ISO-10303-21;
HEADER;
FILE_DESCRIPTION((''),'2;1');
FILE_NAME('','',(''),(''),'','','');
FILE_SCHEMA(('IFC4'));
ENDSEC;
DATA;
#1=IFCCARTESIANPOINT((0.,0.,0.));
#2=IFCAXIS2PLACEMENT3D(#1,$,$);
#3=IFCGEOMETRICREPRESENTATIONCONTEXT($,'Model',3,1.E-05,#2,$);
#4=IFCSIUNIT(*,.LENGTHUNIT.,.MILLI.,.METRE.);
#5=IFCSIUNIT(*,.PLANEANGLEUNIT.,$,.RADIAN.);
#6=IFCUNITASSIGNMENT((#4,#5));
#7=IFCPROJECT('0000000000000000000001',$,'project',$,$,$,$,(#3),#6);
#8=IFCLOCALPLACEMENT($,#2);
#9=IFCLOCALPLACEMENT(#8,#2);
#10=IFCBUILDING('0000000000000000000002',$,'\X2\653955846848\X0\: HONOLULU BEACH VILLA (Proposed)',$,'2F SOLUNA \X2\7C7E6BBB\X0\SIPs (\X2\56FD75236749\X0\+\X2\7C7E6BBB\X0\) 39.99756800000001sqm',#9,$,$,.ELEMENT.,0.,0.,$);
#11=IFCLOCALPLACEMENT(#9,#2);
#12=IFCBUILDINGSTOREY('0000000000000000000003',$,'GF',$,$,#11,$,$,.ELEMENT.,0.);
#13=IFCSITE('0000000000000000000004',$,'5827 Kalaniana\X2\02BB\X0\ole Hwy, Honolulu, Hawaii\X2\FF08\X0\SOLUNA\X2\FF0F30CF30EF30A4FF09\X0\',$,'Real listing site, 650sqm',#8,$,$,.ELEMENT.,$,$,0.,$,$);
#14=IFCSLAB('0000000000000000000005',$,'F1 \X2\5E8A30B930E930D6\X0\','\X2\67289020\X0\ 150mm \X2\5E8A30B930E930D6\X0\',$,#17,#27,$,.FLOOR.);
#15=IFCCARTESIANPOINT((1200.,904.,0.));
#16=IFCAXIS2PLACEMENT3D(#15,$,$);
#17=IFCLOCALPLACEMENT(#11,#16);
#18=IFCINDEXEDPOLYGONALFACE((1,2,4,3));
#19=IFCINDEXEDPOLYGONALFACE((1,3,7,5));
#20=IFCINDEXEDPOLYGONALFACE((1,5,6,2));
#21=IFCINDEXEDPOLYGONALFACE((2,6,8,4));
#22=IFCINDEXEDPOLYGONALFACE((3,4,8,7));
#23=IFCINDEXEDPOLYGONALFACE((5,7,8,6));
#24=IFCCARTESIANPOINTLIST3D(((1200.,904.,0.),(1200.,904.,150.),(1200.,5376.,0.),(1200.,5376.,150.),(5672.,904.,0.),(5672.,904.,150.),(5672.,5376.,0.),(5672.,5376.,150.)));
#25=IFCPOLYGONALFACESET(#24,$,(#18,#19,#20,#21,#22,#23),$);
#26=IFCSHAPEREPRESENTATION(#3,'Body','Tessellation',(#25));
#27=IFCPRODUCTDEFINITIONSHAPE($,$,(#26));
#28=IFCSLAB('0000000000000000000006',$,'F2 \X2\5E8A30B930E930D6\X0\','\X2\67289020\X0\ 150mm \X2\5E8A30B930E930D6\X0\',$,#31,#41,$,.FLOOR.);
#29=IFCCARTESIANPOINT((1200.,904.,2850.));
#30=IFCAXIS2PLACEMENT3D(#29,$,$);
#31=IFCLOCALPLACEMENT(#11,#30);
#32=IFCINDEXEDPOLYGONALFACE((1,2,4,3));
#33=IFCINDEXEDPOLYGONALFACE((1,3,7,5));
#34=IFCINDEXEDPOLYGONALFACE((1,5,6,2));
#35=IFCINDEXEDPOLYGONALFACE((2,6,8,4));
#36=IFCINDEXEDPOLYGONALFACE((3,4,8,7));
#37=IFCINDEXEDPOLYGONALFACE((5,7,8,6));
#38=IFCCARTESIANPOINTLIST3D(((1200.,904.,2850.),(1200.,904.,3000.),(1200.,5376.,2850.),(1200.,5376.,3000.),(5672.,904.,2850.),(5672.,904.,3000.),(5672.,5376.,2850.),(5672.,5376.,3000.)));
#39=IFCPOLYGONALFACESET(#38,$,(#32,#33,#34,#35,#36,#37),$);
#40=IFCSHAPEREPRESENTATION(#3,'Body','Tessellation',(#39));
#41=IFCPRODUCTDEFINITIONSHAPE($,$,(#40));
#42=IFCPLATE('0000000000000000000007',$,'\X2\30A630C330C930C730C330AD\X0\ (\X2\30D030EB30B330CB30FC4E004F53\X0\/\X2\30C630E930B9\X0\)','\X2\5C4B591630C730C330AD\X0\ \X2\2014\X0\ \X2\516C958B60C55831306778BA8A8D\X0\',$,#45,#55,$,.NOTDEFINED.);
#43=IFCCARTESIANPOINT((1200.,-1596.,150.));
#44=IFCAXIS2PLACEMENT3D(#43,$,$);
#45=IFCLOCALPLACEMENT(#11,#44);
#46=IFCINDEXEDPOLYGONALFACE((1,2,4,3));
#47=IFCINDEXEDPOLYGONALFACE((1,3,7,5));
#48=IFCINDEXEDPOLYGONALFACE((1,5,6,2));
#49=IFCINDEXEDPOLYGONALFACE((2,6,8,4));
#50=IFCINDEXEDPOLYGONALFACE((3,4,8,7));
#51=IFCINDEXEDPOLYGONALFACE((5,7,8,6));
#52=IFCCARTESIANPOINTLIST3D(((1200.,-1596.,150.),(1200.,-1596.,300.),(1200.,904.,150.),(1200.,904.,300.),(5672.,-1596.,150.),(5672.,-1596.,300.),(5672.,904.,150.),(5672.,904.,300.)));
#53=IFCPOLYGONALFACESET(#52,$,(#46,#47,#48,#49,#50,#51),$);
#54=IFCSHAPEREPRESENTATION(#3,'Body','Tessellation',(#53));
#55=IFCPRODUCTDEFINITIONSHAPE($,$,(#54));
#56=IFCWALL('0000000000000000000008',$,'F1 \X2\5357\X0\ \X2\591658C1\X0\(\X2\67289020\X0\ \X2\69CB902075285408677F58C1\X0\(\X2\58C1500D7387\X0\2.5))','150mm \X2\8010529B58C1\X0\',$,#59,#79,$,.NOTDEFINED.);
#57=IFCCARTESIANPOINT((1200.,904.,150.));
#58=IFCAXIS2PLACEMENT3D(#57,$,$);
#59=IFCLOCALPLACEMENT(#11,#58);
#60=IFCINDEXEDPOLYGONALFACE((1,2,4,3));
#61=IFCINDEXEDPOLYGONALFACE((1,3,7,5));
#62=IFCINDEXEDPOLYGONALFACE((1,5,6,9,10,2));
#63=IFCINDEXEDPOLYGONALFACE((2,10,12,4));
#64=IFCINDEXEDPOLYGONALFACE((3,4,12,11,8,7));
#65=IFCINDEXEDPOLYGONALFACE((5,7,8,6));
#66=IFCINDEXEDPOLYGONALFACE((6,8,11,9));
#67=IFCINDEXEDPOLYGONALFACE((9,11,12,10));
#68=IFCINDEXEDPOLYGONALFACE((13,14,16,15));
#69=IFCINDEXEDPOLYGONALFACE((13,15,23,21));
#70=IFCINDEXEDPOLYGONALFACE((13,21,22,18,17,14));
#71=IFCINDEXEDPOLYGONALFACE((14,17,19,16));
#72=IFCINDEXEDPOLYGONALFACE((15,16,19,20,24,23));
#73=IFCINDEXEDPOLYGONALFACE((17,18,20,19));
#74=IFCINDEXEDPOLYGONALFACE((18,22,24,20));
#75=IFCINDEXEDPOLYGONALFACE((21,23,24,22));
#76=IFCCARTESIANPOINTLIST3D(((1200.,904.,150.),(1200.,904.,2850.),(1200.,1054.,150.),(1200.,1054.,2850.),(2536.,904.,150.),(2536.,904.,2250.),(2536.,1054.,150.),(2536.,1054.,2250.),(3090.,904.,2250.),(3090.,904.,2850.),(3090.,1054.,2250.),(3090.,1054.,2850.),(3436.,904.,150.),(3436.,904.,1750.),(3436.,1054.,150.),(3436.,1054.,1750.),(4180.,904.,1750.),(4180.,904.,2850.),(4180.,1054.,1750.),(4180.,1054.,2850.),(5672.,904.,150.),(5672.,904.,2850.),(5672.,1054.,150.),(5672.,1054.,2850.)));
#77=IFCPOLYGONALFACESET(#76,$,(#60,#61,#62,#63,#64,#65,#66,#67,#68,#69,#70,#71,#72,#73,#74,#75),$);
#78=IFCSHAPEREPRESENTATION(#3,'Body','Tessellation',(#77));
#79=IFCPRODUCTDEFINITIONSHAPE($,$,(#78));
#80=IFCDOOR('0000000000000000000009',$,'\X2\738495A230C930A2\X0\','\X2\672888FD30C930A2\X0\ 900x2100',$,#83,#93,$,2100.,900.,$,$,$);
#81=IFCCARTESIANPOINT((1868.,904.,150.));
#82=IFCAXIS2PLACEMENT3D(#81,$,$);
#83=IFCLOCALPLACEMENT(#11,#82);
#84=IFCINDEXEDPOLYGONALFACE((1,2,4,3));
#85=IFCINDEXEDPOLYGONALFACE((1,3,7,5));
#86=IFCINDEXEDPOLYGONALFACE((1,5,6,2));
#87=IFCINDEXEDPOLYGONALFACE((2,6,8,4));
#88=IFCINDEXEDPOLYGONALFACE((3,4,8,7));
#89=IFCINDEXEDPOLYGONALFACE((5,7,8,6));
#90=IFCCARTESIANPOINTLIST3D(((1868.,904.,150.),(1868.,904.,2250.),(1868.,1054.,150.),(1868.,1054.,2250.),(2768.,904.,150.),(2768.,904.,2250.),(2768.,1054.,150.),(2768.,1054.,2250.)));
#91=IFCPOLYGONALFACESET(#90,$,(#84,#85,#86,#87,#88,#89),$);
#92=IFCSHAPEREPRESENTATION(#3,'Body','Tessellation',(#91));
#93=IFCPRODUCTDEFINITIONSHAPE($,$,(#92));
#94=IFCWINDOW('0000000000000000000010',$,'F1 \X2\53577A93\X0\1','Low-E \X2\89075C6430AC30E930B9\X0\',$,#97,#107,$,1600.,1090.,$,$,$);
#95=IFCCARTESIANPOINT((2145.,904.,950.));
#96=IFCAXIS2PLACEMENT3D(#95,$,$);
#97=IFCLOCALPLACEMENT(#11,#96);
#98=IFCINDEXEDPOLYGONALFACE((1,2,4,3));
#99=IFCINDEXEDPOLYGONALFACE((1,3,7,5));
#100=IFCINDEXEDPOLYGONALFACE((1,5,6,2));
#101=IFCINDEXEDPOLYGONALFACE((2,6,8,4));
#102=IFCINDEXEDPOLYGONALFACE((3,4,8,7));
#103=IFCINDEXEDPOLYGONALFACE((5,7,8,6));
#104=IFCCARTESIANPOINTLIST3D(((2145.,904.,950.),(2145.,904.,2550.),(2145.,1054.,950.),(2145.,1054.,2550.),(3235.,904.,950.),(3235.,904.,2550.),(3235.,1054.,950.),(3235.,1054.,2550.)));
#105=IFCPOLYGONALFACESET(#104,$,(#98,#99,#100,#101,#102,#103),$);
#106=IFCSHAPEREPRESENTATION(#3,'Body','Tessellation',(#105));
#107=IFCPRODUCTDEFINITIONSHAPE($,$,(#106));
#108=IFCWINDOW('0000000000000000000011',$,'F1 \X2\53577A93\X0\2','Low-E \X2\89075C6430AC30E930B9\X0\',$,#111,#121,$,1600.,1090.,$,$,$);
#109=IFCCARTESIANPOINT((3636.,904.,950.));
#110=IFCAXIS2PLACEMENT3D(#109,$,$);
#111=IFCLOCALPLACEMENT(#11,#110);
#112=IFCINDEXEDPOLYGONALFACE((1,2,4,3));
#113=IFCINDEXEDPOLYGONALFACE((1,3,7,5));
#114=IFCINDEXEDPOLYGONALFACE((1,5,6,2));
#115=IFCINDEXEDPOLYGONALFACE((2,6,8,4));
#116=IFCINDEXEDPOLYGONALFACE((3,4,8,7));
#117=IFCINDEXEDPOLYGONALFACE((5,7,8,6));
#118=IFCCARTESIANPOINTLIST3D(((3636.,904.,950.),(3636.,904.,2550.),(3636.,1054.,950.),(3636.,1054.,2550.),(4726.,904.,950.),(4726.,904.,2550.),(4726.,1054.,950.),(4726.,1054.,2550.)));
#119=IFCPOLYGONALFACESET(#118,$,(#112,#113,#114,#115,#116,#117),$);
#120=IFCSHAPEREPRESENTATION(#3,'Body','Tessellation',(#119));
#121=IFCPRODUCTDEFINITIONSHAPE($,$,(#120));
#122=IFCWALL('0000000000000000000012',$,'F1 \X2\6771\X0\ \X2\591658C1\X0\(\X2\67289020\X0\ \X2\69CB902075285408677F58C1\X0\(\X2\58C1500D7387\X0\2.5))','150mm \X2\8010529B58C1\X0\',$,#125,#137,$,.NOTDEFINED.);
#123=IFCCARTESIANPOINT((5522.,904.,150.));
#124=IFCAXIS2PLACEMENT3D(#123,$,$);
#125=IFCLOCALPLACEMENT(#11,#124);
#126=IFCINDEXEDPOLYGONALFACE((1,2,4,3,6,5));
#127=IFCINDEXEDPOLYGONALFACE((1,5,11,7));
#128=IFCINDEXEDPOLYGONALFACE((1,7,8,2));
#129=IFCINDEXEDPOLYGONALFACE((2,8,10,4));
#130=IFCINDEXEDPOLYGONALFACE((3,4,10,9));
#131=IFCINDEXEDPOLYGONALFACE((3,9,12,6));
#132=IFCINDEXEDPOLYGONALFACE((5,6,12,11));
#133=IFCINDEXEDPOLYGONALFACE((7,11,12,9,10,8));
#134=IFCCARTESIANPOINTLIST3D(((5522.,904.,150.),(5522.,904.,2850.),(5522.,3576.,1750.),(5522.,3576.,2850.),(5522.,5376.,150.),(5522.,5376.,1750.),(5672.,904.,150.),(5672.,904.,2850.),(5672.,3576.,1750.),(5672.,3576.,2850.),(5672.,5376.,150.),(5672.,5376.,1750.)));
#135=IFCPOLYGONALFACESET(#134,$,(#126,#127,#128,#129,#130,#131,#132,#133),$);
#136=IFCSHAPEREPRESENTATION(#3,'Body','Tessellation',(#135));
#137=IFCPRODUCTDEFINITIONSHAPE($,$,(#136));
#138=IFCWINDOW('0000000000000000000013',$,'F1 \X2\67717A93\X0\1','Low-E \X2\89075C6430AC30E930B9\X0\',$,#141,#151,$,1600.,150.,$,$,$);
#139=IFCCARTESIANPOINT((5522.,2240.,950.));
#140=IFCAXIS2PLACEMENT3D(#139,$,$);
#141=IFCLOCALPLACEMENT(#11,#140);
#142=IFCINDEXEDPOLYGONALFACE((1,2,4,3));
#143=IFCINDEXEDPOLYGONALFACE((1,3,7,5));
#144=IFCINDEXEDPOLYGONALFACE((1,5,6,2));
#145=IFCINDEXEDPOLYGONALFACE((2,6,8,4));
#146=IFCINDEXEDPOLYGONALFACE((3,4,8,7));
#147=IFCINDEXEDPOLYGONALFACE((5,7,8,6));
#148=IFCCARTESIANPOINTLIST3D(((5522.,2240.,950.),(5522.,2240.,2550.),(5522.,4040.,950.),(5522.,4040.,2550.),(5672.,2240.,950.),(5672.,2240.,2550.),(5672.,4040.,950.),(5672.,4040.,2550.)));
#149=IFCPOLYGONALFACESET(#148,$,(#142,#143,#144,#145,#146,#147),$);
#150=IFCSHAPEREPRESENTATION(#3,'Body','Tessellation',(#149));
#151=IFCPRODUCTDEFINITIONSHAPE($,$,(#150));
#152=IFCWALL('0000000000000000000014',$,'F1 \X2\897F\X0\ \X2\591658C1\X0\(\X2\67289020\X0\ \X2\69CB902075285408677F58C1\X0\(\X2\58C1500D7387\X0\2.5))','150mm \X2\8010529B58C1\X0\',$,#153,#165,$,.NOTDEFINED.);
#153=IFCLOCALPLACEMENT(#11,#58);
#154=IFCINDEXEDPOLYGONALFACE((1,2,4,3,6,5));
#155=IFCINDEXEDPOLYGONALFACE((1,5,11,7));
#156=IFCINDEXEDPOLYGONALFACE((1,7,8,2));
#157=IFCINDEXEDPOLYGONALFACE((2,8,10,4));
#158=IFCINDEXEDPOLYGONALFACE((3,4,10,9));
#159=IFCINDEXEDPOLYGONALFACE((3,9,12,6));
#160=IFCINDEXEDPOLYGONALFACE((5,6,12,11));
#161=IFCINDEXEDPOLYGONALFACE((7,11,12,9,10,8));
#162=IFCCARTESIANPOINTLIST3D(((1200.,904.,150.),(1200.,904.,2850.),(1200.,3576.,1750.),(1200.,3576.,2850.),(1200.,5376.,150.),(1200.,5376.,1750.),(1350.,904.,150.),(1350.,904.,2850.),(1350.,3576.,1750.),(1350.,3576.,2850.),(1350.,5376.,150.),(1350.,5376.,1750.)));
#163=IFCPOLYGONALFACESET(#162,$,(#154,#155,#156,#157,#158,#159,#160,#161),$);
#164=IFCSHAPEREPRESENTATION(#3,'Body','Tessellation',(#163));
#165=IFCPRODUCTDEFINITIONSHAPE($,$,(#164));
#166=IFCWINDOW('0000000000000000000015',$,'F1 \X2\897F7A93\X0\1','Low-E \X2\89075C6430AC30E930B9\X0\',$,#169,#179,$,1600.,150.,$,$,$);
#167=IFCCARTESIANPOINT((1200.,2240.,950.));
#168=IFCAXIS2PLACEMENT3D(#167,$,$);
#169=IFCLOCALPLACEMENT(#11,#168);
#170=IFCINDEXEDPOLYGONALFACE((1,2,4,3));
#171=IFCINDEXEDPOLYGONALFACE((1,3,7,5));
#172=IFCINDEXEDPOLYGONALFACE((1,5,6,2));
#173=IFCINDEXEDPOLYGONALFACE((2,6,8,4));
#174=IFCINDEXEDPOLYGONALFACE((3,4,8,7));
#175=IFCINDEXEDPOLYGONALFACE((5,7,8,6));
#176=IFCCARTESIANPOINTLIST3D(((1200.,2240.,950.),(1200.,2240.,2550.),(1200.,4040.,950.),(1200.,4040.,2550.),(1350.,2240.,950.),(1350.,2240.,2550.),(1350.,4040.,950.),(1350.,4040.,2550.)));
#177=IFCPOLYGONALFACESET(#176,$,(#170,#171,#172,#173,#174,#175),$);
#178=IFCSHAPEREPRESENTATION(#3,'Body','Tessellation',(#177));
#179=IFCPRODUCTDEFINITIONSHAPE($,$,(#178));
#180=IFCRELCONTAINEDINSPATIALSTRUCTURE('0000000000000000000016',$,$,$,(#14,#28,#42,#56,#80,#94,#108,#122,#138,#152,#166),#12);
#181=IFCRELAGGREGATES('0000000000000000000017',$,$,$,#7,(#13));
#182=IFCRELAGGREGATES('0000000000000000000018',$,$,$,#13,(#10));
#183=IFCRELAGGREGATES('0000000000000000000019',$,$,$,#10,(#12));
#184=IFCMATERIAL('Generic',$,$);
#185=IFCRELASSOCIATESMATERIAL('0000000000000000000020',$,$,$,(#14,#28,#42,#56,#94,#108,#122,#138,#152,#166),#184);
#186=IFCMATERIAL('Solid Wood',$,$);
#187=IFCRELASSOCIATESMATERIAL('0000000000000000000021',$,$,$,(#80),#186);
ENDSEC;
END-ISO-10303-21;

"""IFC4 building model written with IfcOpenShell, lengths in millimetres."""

from ifc_helpers import new_model, si_unit, frame, frame_2d, origin, place, context, project, spatial, rectangle, extrude, material, element, fill, save


model = new_model("IFC4")

# Units and contexts
model_context = context("Model", 3, precision=1e-05, world=origin())
ifc_project = project(units=[si_unit("LENGTHUNIT", "METRE", prefix="MILLI"), si_unit("PLANEANGLEUNIT", "RADIAN")], contexts=[model_context])

# Site, building, storey
site_placement = place(None, origin())
site = spatial("IfcSite", under=ifc_project, at=site_placement, Name="5827 Kalanianaʻole Hwy, Honolulu, Hawaii（SOLUNA／ハワイ）", ObjectType="Real listing site, 650sqm", CompositionType="ELEMENT", RefElevation=0.0)
building_placement = place(site_placement, origin())
building = spatial("IfcBuilding", under=site, at=building_placement, Name="改善案: HONOLULU BEACH VILLA (Proposed)", ObjectType="2F SOLUNA 籾殻SIPs (国産杉+籾殻) 39.99756800000001sqm", CompositionType="ELEMENT", ElevationOfRefHeight=0.0, ElevationOfTerrain=0.0)
storey_placement = place(building_placement, origin())
storey = spatial("IfcBuildingStorey", under=building, at=storey_placement, Name="GF", CompositionType="ELEMENT", Elevation=0.0)

# Slabs
ifc_material_1 = material(Name="Generic")
slab_1_placement = place(storey_placement, frame((1200.0, 904.0, 0.0)))
element("IfcSlab", 1, at=slab_1_placement, inside=storey, material=ifc_material_1, Name="F1 床スラブ", Description="木造 150mm 床スラブ", PredefinedType="FLOOR", context=model_context, shape_type="SweptSolid", body=[
    extrude(rectangle(XDim=4472.0, YDim=4472.0, at=frame_2d((2236.0, 2236.0))), frame((1200.0, 904.0, 0.0)), (0.0, 0.0, 1.0), 150.0),
])
slab_2_placement = place(storey_placement, frame((1200.0, 904.0, 2850.0)))
element("IfcSlab", 2, at=slab_2_placement, inside=storey, material=ifc_material_1, Name="F2 床スラブ", Description="木造 150mm 床スラブ", PredefinedType="FLOOR", context=model_context, shape_type="SweptSolid", body=[
    extrude(rectangle(XDim=4472.0, YDim=4472.0, at=frame_2d((2236.0, 2236.0))), frame((1200.0, 904.0, 2850.0)), (0.0, 0.0, 1.0), 150.0),
])

# Plate
plate_placement = place(storey_placement, frame((1200.0, -1596.0, 150.0)))
element("IfcPlate", 3, at=plate_placement, inside=storey, material=ifc_material_1, Name="ウッドデッキ (バルコニー一体/テラス)", Description="屋外デッキ — 公開情報で確認", PredefinedType="NOTDEFINED", context=model_context, shape_type="SweptSolid", body=[
    extrude(rectangle(XDim=4472.0, YDim=2500.0, at=frame_2d((2236.0, 1250.0))), frame((1200.0, -1596.0, 150.0)), (0.0, 0.0, 1.0), 150.0),
])

# Wall, openings, door, windows
wall_1_placement = place(storey_placement, frame((1200.0, 904.0, 150.0)))
wall_1 = element("IfcWall", 4, at=wall_1_placement, inside=storey, material=ifc_material_1, Name="F1 南 外壁(木造 構造用合板壁(壁倍率2.5))", Description="150mm 耐力壁", PredefinedType="NOTDEFINED", context=model_context, shape_type="SweptSolid", body=[
    extrude(rectangle(XDim=4472.0, YDim=150.0, at=frame_2d((2236.0, 75.0))), frame((1200.0, 904.0, 150.0)), (0.0, 0.0, 1.0), 2700.0),
])
opening_1_placement = place(storey_placement, frame((1868.0, 904.0, 150.0)))
opening_1 = element("IfcOpeningElement", 5, at=opening_1_placement, cuts=wall_1, PredefinedType="NOTDEFINED", context=model_context, shape_type="SweptSolid", body=[
    extrude(rectangle(XDim=900.0, YDim=150.0, at=frame_2d((450.0, 75.0))), frame((1868.0, 904.0, 150.0)), (0.0, 0.0, 1.0), 2100.0),
])
opening_2_placement = place(storey_placement, frame((2145.0, 904.0, 950.0)))
opening_2 = element("IfcOpeningElement", 6, at=opening_2_placement, cuts=wall_1, PredefinedType="NOTDEFINED", context=model_context, shape_type="SweptSolid", body=[
    extrude(rectangle(XDim=1090.0, YDim=150.0, at=frame_2d((545.0, 75.0))), frame((2145.0, 904.0, 950.0)), (0.0, 0.0, 1.0), 1600.0),
])
opening_3_placement = place(storey_placement, frame((3636.0, 904.0, 950.0)))
opening_3 = element("IfcOpeningElement", 7, at=opening_3_placement, cuts=wall_1, PredefinedType="NOTDEFINED", context=model_context, shape_type="SweptSolid", body=[
    extrude(rectangle(XDim=1090.0, YDim=150.0, at=frame_2d((545.0, 75.0))), frame((3636.0, 904.0, 950.0)), (0.0, 0.0, 1.0), 1600.0),
])
ifc_material_2 = material(Name="Solid Wood")
door_placement = place(storey_placement, frame((1868.0, 904.0, 150.0)))
door = element("IfcDoor", 8, at=door_placement, inside=storey, material=ifc_material_2, Name="玄関ドア", Description="木製ドア 900x2100", OverallHeight=2100.0, OverallWidth=900.0, context=model_context, shape_type="SweptSolid", body=[
    extrude(rectangle(XDim=900.0, YDim=150.0, at=frame_2d((450.0, 75.0))), frame((1868.0, 904.0, 150.0)), (0.0, 0.0, 1.0), 2100.0),
])
fill(opening_1, door)
window_1_placement = place(storey_placement, frame((2145.0, 904.0, 950.0)))
window_1 = element("IfcWindow", 9, at=window_1_placement, inside=storey, material=ifc_material_1, Name="F1 南窓1", Description="Low-E 複層ガラス", OverallHeight=1600.0, OverallWidth=1090.0, context=model_context, shape_type="SweptSolid", body=[
    extrude(rectangle(XDim=1090.0, YDim=150.0, at=frame_2d((545.0, 75.0))), frame((2145.0, 904.0, 950.0)), (0.0, 0.0, 1.0), 1600.0),
])
fill(opening_2, window_1)
window_2_placement = place(storey_placement, frame((3636.0, 904.0, 950.0)))
window_2 = element("IfcWindow", 10, at=window_2_placement, inside=storey, material=ifc_material_1, Name="F1 南窓2", Description="Low-E 複層ガラス", OverallHeight=1600.0, OverallWidth=1090.0, context=model_context, shape_type="SweptSolid", body=[
    extrude(rectangle(XDim=1090.0, YDim=150.0, at=frame_2d((545.0, 75.0))), frame((3636.0, 904.0, 950.0)), (0.0, 0.0, 1.0), 1600.0),
])
fill(opening_3, window_2)

# Walls, openings, windows
wall_2_placement = place(storey_placement, frame((5522.0, 904.0, 150.0)))
wall_2 = element("IfcWall", 11, at=wall_2_placement, inside=storey, material=ifc_material_1, Name="F1 東 外壁(木造 構造用合板壁(壁倍率2.5))", Description="150mm 耐力壁", PredefinedType="NOTDEFINED", context=model_context, shape_type="SweptSolid", body=[
    extrude(rectangle(XDim=150.0, YDim=4472.0, at=frame_2d((75.0, 2236.0))), frame((5522.0, 904.0, 150.0)), (0.0, 0.0, 1.0), 2700.0),
])
opening_4_placement = place(storey_placement, frame((5522.0, 2240.0, 950.0)))
opening_4 = element("IfcOpeningElement", 12, at=opening_4_placement, cuts=wall_2, PredefinedType="NOTDEFINED", context=model_context, shape_type="SweptSolid", body=[
    extrude(rectangle(XDim=150.0, YDim=1800.0, at=frame_2d((75.0, 900.0))), frame((5522.0, 2240.0, 950.0)), (0.0, 0.0, 1.0), 1600.0),
])
window_3_placement = place(storey_placement, frame((5522.0, 2240.0, 950.0)))
window_3 = element("IfcWindow", 13, at=window_3_placement, inside=storey, material=ifc_material_1, Name="F1 東窓1", Description="Low-E 複層ガラス", OverallHeight=1600.0, OverallWidth=150.0, context=model_context, shape_type="SweptSolid", body=[
    extrude(rectangle(XDim=150.0, YDim=1800.0, at=frame_2d((75.0, 900.0))), frame((5522.0, 2240.0, 950.0)), (0.0, 0.0, 1.0), 1600.0),
])
fill(opening_4, window_3)
wall_3_placement = place(storey_placement, frame((1200.0, 904.0, 150.0)))
wall_3 = element("IfcWall", 14, at=wall_3_placement, inside=storey, material=ifc_material_1, Name="F1 西 外壁(木造 構造用合板壁(壁倍率2.5))", Description="150mm 耐力壁", PredefinedType="NOTDEFINED", context=model_context, shape_type="SweptSolid", body=[
    extrude(rectangle(XDim=150.0, YDim=4472.0, at=frame_2d((75.0, 2236.0))), frame((1200.0, 904.0, 150.0)), (0.0, 0.0, 1.0), 2700.0),
])
opening_5_placement = place(storey_placement, frame((1200.0, 2240.0, 950.0)))
opening_5 = element("IfcOpeningElement", 15, at=opening_5_placement, cuts=wall_3, PredefinedType="NOTDEFINED", context=model_context, shape_type="SweptSolid", body=[
    extrude(rectangle(XDim=150.0, YDim=1800.0, at=frame_2d((75.0, 900.0))), frame((1200.0, 2240.0, 950.0)), (0.0, 0.0, 1.0), 1600.0),
])
window_4_placement = place(storey_placement, frame((1200.0, 2240.0, 950.0)))
window_4 = element("IfcWindow", 16, at=window_4_placement, inside=storey, material=ifc_material_1, Name="F1 西窓1", Description="Low-E 複層ガラス", OverallHeight=1600.0, OverallWidth=150.0, context=model_context, shape_type="SweptSolid", body=[
    extrude(rectangle(XDim=150.0, YDim=1800.0, at=frame_2d((75.0, 900.0))), frame((1200.0, 2240.0, 950.0)), (0.0, 0.0, 1.0), 1600.0),
])
fill(opening_5, window_4)

save(model, "model.ifc")
